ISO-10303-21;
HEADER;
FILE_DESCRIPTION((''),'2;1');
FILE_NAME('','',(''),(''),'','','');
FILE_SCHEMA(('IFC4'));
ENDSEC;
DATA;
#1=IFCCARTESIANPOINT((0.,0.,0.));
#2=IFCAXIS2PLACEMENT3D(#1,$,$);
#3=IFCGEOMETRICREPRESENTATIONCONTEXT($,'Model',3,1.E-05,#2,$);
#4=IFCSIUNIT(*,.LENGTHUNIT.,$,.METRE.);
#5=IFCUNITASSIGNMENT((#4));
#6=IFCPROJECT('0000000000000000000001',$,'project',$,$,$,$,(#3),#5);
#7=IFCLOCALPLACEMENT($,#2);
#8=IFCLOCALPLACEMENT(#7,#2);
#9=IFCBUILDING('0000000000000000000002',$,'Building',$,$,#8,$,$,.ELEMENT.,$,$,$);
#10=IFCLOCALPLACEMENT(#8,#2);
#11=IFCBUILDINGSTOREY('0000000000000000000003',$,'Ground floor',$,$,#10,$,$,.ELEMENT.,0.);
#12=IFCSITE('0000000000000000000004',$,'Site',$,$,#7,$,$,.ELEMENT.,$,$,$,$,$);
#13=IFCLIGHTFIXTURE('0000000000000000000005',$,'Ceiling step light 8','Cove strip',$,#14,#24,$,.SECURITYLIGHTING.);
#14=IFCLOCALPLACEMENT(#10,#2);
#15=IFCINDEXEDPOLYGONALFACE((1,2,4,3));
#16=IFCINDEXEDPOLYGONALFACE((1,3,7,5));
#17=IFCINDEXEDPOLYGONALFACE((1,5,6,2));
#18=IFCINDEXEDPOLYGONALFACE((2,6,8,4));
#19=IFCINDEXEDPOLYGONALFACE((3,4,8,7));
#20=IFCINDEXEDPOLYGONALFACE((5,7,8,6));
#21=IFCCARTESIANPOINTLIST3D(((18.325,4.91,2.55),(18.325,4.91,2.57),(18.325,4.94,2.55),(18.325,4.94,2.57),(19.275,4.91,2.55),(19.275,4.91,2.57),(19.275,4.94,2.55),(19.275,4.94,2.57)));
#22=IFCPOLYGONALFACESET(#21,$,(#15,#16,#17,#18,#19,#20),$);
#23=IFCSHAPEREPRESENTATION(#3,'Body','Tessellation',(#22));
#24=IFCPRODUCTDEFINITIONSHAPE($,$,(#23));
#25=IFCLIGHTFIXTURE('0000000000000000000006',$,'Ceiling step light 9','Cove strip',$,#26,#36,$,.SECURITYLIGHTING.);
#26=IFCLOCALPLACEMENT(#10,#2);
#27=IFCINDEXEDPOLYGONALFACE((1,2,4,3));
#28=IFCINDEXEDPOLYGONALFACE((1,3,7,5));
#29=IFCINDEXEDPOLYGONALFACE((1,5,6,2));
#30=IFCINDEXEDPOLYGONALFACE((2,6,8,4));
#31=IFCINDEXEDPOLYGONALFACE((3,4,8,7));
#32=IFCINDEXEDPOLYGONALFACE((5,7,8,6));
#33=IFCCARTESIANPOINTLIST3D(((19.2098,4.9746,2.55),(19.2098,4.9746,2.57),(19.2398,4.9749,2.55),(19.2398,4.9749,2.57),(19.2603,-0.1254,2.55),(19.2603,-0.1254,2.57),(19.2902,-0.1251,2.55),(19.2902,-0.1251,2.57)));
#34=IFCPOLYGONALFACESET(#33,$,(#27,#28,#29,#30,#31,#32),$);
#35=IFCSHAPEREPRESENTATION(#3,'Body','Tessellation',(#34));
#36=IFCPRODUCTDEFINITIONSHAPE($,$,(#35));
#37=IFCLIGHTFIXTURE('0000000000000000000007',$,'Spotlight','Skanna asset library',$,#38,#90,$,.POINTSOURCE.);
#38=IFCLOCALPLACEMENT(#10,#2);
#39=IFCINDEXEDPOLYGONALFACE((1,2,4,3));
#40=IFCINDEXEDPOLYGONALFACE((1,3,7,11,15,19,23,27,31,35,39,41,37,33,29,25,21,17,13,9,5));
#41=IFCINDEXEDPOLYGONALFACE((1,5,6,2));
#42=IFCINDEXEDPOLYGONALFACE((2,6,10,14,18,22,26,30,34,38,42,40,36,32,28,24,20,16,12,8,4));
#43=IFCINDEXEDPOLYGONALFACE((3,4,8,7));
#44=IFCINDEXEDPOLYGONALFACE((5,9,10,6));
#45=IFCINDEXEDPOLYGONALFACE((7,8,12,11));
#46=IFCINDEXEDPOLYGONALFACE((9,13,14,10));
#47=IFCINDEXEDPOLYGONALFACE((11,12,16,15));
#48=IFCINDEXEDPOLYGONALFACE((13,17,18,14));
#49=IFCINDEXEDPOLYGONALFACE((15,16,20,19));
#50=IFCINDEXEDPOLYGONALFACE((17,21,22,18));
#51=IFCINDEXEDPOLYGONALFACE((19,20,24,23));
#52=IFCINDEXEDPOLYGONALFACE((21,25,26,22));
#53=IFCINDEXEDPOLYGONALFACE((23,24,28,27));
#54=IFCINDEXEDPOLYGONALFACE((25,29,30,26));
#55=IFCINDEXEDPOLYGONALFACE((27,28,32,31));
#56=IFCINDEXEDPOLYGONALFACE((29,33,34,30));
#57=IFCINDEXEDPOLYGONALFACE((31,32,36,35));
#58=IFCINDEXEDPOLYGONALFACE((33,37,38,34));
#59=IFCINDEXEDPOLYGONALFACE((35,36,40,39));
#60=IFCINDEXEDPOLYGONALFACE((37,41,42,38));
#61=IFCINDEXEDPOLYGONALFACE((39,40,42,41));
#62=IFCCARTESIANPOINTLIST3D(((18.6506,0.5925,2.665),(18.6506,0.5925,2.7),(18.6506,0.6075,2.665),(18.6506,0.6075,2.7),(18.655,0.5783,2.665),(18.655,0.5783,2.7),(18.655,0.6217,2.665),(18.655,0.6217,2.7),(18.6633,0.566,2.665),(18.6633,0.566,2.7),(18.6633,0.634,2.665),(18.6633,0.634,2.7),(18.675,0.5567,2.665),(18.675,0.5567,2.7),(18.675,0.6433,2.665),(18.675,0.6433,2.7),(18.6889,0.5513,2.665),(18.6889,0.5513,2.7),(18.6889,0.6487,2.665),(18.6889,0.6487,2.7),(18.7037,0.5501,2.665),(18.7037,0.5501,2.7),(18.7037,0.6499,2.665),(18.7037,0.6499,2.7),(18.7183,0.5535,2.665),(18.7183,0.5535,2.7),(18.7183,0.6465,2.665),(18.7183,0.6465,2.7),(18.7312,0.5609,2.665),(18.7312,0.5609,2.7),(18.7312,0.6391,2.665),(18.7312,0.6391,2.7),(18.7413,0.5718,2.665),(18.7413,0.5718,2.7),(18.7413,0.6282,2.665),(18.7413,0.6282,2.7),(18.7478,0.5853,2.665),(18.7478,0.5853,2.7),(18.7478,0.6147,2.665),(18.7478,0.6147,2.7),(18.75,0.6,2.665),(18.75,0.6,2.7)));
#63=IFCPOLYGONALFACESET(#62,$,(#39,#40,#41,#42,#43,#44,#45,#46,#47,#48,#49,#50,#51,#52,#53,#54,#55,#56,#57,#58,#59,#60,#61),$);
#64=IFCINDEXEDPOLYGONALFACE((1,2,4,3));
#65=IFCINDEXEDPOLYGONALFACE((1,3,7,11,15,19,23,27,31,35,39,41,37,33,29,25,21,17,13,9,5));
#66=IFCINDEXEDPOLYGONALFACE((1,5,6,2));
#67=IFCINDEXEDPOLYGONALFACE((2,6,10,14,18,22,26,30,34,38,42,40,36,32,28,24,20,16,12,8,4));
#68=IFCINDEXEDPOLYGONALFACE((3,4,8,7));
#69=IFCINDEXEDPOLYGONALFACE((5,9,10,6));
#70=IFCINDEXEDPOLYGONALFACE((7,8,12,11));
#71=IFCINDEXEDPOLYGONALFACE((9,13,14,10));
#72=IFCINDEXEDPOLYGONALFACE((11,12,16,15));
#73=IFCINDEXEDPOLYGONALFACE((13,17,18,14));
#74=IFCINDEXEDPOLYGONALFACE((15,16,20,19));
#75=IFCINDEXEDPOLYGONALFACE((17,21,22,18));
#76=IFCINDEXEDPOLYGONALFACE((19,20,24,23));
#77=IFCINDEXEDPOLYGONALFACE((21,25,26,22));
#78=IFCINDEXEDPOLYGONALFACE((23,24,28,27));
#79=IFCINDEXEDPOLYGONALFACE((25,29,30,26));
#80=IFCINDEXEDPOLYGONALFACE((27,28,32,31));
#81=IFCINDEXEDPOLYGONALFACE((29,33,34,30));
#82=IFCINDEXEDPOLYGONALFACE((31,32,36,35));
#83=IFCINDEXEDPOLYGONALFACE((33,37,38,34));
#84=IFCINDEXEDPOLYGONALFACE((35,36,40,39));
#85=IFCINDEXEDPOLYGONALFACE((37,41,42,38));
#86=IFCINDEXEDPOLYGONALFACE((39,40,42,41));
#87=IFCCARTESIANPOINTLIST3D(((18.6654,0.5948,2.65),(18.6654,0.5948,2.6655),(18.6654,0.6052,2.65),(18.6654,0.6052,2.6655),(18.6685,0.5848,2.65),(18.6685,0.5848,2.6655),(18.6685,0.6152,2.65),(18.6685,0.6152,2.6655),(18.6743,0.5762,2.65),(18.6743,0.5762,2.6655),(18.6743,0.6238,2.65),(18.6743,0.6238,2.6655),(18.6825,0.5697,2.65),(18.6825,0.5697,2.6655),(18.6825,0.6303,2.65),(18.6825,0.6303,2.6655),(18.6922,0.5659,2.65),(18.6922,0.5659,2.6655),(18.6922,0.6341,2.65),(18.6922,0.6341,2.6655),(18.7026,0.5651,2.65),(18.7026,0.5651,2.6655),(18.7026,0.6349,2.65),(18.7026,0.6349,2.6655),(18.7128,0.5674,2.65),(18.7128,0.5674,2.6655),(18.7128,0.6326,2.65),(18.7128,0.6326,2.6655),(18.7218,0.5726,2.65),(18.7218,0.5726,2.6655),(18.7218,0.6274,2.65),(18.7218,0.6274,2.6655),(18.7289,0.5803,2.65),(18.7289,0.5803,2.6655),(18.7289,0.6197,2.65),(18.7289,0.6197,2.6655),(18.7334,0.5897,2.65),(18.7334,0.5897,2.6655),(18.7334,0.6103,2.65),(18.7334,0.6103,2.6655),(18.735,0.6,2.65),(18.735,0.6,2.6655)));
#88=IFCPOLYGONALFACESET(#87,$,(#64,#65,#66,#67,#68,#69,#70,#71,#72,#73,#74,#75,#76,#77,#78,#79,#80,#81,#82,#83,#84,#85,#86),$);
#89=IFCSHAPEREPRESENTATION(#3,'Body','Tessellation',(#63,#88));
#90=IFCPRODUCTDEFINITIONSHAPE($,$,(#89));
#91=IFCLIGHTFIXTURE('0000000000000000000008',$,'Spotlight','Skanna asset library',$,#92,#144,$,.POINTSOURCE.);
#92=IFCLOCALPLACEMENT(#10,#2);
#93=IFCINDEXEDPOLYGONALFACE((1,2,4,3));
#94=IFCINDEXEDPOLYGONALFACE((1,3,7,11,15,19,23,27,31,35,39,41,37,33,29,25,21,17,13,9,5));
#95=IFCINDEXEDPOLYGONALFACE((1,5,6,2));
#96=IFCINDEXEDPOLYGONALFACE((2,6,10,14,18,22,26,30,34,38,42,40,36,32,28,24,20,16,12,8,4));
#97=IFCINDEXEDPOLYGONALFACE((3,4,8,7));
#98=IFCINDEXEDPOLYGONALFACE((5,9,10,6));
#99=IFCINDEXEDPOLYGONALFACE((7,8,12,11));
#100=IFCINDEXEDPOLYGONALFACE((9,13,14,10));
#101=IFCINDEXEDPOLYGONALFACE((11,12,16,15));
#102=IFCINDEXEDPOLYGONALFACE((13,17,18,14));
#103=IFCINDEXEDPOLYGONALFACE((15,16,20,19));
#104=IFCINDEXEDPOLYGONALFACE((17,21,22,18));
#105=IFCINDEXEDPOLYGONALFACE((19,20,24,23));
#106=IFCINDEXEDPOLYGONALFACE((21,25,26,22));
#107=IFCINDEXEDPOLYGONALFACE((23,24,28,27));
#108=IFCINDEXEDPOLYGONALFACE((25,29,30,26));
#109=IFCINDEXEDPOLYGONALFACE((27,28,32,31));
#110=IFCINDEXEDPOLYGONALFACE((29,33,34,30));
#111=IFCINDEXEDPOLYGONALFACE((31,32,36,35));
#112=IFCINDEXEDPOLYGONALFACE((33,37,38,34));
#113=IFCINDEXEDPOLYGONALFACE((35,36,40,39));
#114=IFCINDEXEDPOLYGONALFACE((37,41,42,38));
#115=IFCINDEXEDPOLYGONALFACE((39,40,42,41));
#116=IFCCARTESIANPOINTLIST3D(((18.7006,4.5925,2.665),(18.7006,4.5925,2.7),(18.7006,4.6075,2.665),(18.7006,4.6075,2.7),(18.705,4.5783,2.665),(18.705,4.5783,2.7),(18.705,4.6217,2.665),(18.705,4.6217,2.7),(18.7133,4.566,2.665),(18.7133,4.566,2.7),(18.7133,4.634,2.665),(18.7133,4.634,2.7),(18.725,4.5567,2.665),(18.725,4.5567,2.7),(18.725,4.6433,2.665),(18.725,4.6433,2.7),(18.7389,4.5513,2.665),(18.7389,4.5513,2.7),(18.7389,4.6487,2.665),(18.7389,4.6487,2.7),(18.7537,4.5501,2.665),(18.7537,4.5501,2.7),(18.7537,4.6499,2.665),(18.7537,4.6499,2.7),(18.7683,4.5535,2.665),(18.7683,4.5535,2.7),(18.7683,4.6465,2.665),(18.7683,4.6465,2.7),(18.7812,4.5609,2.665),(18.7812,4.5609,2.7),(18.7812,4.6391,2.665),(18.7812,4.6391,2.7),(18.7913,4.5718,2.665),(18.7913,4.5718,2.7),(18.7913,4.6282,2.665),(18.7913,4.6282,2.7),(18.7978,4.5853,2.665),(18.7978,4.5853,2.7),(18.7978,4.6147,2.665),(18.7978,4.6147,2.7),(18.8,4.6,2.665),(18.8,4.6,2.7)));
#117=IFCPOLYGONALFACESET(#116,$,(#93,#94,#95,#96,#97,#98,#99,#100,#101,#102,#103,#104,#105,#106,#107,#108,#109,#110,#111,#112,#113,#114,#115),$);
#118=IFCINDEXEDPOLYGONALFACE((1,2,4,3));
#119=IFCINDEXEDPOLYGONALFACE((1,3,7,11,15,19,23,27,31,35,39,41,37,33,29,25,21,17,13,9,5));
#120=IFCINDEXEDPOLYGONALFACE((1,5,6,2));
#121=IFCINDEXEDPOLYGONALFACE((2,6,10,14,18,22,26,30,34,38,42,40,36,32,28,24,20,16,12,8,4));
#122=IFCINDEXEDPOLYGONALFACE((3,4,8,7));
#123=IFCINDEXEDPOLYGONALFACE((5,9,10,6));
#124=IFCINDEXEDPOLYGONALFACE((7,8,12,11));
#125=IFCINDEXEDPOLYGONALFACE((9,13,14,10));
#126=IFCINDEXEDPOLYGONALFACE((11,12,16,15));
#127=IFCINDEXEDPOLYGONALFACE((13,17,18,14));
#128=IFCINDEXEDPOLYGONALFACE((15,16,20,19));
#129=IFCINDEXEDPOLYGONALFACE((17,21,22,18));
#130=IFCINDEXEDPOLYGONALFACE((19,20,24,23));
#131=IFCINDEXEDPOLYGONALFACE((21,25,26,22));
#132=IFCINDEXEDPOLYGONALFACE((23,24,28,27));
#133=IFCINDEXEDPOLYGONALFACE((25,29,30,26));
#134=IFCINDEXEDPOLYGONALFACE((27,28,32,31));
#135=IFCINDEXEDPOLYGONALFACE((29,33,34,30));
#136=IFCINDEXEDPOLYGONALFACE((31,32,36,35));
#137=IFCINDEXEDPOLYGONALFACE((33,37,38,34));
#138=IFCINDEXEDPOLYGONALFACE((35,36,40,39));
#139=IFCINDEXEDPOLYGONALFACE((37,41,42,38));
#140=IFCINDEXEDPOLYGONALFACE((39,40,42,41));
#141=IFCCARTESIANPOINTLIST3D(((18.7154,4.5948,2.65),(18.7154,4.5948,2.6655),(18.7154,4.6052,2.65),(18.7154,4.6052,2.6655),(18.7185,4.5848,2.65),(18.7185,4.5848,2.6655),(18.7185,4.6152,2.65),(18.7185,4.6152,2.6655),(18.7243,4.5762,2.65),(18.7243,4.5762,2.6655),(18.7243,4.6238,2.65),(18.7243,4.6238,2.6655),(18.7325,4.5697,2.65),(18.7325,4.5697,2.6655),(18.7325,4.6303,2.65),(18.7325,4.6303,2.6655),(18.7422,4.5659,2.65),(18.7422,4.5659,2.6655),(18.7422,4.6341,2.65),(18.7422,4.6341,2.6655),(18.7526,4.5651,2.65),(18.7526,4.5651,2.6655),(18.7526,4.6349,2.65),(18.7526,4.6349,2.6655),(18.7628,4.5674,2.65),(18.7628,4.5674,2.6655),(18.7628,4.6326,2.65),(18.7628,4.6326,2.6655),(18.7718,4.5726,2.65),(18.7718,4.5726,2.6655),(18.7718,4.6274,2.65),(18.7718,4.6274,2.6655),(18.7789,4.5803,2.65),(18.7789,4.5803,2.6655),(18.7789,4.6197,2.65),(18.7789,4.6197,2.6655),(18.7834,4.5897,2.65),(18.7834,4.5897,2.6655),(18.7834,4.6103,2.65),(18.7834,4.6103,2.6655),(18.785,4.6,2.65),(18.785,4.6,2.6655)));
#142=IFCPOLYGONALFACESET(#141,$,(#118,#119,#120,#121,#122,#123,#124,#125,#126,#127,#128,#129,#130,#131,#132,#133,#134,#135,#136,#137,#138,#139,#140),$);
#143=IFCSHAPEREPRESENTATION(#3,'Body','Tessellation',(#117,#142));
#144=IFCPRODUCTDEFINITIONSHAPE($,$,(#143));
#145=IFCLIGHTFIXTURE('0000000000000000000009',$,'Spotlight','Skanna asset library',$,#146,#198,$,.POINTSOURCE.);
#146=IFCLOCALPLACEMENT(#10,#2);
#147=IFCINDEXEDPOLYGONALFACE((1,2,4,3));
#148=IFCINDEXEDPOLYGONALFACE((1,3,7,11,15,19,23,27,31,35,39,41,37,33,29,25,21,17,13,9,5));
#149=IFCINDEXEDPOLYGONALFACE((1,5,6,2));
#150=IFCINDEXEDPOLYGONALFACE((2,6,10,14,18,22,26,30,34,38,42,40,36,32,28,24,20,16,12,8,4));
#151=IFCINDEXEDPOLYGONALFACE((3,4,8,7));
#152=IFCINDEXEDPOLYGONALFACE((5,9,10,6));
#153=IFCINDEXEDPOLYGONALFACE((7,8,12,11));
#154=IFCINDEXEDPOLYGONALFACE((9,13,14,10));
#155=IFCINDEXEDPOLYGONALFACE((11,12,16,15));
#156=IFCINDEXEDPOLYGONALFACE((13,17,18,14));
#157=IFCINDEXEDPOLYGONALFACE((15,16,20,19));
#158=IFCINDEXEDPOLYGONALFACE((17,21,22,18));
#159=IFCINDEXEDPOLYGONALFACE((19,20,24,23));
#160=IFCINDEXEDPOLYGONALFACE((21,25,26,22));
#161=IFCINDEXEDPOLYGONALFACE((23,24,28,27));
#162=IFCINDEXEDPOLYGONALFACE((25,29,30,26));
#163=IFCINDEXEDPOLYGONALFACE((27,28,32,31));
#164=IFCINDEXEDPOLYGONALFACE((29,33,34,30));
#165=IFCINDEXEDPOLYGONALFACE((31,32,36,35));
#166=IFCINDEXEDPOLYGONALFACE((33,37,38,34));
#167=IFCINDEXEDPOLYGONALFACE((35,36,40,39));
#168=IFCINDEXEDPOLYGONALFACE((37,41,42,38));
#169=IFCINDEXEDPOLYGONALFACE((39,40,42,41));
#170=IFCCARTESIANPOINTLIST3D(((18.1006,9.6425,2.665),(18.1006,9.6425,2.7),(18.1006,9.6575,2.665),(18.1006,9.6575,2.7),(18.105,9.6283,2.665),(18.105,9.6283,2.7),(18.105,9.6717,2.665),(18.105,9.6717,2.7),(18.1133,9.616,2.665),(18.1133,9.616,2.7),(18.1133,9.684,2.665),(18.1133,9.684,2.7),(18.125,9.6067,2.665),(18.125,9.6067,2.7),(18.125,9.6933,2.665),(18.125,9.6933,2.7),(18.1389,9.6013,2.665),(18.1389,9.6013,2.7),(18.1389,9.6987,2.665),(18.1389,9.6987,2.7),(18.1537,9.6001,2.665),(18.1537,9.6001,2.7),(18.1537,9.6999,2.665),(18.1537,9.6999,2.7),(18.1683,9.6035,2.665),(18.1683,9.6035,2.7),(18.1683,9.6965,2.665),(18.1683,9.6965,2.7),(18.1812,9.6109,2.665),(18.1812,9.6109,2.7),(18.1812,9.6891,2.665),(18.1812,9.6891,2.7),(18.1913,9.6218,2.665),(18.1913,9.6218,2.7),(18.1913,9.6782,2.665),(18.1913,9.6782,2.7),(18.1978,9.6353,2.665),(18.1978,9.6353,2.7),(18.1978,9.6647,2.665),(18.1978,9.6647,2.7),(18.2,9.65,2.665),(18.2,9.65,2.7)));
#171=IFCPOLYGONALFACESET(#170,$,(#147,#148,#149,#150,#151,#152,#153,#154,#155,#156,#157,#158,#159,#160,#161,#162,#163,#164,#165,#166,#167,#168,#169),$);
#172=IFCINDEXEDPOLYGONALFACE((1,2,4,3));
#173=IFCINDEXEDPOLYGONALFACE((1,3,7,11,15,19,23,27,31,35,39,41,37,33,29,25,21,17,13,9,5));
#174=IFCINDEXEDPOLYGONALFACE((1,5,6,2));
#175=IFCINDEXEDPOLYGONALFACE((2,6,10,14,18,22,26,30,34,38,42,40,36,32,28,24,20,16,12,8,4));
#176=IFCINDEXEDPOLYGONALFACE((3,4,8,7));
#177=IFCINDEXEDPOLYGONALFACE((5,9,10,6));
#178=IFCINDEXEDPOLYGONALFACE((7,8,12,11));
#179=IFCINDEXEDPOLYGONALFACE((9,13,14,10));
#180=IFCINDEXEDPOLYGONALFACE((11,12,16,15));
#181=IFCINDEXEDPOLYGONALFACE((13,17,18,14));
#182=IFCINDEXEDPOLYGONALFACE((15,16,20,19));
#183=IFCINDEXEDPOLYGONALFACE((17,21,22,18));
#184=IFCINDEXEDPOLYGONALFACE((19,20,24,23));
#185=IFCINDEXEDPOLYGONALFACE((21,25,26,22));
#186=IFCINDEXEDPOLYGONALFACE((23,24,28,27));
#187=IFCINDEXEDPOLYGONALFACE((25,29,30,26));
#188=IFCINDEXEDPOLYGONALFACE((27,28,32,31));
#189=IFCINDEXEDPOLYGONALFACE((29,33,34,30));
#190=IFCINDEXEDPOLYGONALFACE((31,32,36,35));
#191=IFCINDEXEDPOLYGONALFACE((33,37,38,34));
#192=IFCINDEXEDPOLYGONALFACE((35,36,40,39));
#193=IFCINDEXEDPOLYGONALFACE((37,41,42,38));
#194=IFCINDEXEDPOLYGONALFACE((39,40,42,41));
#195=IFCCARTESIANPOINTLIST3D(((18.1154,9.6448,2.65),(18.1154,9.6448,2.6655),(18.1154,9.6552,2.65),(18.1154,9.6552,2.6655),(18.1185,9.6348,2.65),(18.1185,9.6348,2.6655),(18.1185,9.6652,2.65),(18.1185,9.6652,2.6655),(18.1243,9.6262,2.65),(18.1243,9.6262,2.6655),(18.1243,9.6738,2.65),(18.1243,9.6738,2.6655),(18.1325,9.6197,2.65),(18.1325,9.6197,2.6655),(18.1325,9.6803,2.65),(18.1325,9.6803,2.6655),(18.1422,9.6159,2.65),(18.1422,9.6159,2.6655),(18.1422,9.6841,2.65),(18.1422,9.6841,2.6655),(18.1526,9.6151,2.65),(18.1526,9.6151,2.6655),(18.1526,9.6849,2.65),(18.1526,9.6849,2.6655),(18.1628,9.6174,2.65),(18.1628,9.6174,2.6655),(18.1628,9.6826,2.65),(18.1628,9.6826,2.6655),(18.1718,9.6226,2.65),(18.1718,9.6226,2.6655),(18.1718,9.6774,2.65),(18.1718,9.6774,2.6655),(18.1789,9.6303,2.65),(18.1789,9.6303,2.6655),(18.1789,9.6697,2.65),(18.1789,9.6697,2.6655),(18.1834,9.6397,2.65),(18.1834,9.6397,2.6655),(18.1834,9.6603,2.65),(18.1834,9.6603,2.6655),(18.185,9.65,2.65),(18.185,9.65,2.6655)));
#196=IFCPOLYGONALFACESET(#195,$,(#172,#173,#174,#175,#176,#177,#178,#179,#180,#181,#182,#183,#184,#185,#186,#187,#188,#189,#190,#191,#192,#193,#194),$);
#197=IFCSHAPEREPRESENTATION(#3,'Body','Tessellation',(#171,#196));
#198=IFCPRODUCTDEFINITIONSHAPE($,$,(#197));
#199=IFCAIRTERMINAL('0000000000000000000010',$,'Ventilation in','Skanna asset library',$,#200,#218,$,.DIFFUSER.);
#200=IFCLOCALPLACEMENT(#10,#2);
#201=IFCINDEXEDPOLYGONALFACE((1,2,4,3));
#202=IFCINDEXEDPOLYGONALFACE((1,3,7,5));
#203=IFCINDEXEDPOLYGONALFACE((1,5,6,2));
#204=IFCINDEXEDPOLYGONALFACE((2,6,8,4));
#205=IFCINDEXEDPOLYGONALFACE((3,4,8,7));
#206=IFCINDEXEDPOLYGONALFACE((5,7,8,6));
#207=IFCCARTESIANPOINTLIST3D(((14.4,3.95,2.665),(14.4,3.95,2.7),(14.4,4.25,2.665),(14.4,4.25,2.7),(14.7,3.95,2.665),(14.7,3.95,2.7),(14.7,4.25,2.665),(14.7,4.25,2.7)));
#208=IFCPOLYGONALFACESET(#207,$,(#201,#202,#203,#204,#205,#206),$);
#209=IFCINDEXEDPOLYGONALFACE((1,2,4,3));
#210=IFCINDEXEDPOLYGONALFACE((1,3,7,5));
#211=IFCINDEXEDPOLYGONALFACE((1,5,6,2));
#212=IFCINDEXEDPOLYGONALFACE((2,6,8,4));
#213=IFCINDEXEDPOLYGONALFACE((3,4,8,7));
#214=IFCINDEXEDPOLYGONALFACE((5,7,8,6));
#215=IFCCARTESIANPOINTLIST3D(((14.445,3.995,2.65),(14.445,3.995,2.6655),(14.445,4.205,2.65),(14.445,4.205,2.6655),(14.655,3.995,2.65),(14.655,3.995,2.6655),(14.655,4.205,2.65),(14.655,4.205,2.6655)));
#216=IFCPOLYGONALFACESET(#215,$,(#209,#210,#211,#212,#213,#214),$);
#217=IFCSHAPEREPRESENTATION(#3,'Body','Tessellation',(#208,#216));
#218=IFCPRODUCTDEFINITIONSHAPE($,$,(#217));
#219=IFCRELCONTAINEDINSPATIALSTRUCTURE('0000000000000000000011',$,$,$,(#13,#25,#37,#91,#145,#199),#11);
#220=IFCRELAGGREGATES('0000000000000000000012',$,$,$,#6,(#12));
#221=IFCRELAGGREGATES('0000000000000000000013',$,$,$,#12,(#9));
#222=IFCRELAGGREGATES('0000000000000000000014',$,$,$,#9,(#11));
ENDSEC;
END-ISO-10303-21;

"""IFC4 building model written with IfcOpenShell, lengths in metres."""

from ifc_helpers import new_model, si_unit, frame, origin, origin_2d, place, context, project, spatial, rectangle, circle, extrude, element, save


model = new_model("IFC4")

# Units and contexts
model_context = context("Model", 3, precision=1e-05, world=origin())
ifc_project = project(units=[si_unit("LENGTHUNIT", "METRE")], contexts=[model_context])

# Site, building, storey
site_placement = place(None, origin())
site = spatial("IfcSite", under=ifc_project, at=site_placement, Name="Site", CompositionType="ELEMENT")
building_placement = place(site_placement, origin())
building = spatial("IfcBuilding", under=site, at=building_placement, Name="Building", CompositionType="ELEMENT")
storey_placement = place(building_placement, origin())
storey = spatial("IfcBuildingStorey", under=building, at=storey_placement, Name="Ground floor", CompositionType="ELEMENT", Elevation=0.0)

# Light fixtures
light_fixture_1_placement = place(storey_placement, frame((18.8, 4.925, 2.55), z_axis=(0.0, 0.0, 1.0), x_axis=(1.0, 0.0, 0.0)))
element("IfcLightFixture", 1, at=light_fixture_1_placement, inside=storey, Name="Ceiling step light 8", Description="Cove strip", PredefinedType="SECURITYLIGHTING", context=model_context, shape_type="SweptSolid", body=[
    extrude(rectangle(XDim=0.95, YDim=0.03, at=origin_2d()), origin(), (0.0, 0.0, 1.0), 0.02),
])
light_fixture_2_placement = place(storey_placement, frame((19.25, 2.4248, 2.55), z_axis=(0.0, 0.0, 1.0), x_axis=(0.009901, -0.999951, 0.0)))
element("IfcLightFixture", 2, at=light_fixture_2_placement, inside=storey, Name="Ceiling step light 9", Description="Cove strip", PredefinedType="SECURITYLIGHTING", context=model_context, shape_type="SweptSolid", body=[
    extrude(rectangle(XDim=5.1002, YDim=0.03, at=origin_2d()), origin(), (0.0, 0.0, 1.0), 0.02),
])
for number, where, z_axis, x_axis, name in (
    (3, (18.7, 0.6, 2.65), (0.0, 0.0, 1.0), (1.0, 0.0, 0.0), "Spotlight"),
    (4, (18.75, 4.6, 2.65), (0.0, 0.0, 1.0), (1.0, 0.0, 0.0), "Spotlight"),
    (5, (18.15, 9.65, 2.65), (0.0, 0.0, 1.0), (1.0, 0.0, 0.0), "Spotlight"),
):
    element("IfcLightFixture", number, at=place(storey_placement, frame(where, z_axis=z_axis, x_axis=x_axis)), inside=storey, Name=name, Description="Skanna asset library", PredefinedType="POINTSOURCE", context=model_context, shape_type="SweptSolid", body=[
        extrude(circle(Radius=0.05, at=origin_2d()), frame((0.0, 0.0, 0.015)), (0.0, 0.0, 1.0), 0.035),
        extrude(circle(Radius=0.035, at=origin_2d()), origin(), (0.0, 0.0, 1.0), 0.0155),
    ])

# Air terminal
air_terminal_placement = place(storey_placement, frame((14.55, 4.1, 2.65), z_axis=(0.0, 0.0, 1.0), x_axis=(1.0, 0.0, 0.0)))
element("IfcAirTerminal", 6, at=air_terminal_placement, inside=storey, Name="Ventilation in", Description="Skanna asset library", PredefinedType="DIFFUSER", context=model_context, shape_type="SweptSolid", body=[
    extrude(rectangle(XDim=0.3, YDim=0.3, at=origin_2d()), frame((0.0, 0.0, 0.015)), (0.0, 0.0, 1.0), 0.035),
    extrude(rectangle(XDim=0.21, YDim=0.21, at=origin_2d()), origin(), (0.0, 0.0, 1.0), 0.0155),
])

save(model, "model.ifc")
